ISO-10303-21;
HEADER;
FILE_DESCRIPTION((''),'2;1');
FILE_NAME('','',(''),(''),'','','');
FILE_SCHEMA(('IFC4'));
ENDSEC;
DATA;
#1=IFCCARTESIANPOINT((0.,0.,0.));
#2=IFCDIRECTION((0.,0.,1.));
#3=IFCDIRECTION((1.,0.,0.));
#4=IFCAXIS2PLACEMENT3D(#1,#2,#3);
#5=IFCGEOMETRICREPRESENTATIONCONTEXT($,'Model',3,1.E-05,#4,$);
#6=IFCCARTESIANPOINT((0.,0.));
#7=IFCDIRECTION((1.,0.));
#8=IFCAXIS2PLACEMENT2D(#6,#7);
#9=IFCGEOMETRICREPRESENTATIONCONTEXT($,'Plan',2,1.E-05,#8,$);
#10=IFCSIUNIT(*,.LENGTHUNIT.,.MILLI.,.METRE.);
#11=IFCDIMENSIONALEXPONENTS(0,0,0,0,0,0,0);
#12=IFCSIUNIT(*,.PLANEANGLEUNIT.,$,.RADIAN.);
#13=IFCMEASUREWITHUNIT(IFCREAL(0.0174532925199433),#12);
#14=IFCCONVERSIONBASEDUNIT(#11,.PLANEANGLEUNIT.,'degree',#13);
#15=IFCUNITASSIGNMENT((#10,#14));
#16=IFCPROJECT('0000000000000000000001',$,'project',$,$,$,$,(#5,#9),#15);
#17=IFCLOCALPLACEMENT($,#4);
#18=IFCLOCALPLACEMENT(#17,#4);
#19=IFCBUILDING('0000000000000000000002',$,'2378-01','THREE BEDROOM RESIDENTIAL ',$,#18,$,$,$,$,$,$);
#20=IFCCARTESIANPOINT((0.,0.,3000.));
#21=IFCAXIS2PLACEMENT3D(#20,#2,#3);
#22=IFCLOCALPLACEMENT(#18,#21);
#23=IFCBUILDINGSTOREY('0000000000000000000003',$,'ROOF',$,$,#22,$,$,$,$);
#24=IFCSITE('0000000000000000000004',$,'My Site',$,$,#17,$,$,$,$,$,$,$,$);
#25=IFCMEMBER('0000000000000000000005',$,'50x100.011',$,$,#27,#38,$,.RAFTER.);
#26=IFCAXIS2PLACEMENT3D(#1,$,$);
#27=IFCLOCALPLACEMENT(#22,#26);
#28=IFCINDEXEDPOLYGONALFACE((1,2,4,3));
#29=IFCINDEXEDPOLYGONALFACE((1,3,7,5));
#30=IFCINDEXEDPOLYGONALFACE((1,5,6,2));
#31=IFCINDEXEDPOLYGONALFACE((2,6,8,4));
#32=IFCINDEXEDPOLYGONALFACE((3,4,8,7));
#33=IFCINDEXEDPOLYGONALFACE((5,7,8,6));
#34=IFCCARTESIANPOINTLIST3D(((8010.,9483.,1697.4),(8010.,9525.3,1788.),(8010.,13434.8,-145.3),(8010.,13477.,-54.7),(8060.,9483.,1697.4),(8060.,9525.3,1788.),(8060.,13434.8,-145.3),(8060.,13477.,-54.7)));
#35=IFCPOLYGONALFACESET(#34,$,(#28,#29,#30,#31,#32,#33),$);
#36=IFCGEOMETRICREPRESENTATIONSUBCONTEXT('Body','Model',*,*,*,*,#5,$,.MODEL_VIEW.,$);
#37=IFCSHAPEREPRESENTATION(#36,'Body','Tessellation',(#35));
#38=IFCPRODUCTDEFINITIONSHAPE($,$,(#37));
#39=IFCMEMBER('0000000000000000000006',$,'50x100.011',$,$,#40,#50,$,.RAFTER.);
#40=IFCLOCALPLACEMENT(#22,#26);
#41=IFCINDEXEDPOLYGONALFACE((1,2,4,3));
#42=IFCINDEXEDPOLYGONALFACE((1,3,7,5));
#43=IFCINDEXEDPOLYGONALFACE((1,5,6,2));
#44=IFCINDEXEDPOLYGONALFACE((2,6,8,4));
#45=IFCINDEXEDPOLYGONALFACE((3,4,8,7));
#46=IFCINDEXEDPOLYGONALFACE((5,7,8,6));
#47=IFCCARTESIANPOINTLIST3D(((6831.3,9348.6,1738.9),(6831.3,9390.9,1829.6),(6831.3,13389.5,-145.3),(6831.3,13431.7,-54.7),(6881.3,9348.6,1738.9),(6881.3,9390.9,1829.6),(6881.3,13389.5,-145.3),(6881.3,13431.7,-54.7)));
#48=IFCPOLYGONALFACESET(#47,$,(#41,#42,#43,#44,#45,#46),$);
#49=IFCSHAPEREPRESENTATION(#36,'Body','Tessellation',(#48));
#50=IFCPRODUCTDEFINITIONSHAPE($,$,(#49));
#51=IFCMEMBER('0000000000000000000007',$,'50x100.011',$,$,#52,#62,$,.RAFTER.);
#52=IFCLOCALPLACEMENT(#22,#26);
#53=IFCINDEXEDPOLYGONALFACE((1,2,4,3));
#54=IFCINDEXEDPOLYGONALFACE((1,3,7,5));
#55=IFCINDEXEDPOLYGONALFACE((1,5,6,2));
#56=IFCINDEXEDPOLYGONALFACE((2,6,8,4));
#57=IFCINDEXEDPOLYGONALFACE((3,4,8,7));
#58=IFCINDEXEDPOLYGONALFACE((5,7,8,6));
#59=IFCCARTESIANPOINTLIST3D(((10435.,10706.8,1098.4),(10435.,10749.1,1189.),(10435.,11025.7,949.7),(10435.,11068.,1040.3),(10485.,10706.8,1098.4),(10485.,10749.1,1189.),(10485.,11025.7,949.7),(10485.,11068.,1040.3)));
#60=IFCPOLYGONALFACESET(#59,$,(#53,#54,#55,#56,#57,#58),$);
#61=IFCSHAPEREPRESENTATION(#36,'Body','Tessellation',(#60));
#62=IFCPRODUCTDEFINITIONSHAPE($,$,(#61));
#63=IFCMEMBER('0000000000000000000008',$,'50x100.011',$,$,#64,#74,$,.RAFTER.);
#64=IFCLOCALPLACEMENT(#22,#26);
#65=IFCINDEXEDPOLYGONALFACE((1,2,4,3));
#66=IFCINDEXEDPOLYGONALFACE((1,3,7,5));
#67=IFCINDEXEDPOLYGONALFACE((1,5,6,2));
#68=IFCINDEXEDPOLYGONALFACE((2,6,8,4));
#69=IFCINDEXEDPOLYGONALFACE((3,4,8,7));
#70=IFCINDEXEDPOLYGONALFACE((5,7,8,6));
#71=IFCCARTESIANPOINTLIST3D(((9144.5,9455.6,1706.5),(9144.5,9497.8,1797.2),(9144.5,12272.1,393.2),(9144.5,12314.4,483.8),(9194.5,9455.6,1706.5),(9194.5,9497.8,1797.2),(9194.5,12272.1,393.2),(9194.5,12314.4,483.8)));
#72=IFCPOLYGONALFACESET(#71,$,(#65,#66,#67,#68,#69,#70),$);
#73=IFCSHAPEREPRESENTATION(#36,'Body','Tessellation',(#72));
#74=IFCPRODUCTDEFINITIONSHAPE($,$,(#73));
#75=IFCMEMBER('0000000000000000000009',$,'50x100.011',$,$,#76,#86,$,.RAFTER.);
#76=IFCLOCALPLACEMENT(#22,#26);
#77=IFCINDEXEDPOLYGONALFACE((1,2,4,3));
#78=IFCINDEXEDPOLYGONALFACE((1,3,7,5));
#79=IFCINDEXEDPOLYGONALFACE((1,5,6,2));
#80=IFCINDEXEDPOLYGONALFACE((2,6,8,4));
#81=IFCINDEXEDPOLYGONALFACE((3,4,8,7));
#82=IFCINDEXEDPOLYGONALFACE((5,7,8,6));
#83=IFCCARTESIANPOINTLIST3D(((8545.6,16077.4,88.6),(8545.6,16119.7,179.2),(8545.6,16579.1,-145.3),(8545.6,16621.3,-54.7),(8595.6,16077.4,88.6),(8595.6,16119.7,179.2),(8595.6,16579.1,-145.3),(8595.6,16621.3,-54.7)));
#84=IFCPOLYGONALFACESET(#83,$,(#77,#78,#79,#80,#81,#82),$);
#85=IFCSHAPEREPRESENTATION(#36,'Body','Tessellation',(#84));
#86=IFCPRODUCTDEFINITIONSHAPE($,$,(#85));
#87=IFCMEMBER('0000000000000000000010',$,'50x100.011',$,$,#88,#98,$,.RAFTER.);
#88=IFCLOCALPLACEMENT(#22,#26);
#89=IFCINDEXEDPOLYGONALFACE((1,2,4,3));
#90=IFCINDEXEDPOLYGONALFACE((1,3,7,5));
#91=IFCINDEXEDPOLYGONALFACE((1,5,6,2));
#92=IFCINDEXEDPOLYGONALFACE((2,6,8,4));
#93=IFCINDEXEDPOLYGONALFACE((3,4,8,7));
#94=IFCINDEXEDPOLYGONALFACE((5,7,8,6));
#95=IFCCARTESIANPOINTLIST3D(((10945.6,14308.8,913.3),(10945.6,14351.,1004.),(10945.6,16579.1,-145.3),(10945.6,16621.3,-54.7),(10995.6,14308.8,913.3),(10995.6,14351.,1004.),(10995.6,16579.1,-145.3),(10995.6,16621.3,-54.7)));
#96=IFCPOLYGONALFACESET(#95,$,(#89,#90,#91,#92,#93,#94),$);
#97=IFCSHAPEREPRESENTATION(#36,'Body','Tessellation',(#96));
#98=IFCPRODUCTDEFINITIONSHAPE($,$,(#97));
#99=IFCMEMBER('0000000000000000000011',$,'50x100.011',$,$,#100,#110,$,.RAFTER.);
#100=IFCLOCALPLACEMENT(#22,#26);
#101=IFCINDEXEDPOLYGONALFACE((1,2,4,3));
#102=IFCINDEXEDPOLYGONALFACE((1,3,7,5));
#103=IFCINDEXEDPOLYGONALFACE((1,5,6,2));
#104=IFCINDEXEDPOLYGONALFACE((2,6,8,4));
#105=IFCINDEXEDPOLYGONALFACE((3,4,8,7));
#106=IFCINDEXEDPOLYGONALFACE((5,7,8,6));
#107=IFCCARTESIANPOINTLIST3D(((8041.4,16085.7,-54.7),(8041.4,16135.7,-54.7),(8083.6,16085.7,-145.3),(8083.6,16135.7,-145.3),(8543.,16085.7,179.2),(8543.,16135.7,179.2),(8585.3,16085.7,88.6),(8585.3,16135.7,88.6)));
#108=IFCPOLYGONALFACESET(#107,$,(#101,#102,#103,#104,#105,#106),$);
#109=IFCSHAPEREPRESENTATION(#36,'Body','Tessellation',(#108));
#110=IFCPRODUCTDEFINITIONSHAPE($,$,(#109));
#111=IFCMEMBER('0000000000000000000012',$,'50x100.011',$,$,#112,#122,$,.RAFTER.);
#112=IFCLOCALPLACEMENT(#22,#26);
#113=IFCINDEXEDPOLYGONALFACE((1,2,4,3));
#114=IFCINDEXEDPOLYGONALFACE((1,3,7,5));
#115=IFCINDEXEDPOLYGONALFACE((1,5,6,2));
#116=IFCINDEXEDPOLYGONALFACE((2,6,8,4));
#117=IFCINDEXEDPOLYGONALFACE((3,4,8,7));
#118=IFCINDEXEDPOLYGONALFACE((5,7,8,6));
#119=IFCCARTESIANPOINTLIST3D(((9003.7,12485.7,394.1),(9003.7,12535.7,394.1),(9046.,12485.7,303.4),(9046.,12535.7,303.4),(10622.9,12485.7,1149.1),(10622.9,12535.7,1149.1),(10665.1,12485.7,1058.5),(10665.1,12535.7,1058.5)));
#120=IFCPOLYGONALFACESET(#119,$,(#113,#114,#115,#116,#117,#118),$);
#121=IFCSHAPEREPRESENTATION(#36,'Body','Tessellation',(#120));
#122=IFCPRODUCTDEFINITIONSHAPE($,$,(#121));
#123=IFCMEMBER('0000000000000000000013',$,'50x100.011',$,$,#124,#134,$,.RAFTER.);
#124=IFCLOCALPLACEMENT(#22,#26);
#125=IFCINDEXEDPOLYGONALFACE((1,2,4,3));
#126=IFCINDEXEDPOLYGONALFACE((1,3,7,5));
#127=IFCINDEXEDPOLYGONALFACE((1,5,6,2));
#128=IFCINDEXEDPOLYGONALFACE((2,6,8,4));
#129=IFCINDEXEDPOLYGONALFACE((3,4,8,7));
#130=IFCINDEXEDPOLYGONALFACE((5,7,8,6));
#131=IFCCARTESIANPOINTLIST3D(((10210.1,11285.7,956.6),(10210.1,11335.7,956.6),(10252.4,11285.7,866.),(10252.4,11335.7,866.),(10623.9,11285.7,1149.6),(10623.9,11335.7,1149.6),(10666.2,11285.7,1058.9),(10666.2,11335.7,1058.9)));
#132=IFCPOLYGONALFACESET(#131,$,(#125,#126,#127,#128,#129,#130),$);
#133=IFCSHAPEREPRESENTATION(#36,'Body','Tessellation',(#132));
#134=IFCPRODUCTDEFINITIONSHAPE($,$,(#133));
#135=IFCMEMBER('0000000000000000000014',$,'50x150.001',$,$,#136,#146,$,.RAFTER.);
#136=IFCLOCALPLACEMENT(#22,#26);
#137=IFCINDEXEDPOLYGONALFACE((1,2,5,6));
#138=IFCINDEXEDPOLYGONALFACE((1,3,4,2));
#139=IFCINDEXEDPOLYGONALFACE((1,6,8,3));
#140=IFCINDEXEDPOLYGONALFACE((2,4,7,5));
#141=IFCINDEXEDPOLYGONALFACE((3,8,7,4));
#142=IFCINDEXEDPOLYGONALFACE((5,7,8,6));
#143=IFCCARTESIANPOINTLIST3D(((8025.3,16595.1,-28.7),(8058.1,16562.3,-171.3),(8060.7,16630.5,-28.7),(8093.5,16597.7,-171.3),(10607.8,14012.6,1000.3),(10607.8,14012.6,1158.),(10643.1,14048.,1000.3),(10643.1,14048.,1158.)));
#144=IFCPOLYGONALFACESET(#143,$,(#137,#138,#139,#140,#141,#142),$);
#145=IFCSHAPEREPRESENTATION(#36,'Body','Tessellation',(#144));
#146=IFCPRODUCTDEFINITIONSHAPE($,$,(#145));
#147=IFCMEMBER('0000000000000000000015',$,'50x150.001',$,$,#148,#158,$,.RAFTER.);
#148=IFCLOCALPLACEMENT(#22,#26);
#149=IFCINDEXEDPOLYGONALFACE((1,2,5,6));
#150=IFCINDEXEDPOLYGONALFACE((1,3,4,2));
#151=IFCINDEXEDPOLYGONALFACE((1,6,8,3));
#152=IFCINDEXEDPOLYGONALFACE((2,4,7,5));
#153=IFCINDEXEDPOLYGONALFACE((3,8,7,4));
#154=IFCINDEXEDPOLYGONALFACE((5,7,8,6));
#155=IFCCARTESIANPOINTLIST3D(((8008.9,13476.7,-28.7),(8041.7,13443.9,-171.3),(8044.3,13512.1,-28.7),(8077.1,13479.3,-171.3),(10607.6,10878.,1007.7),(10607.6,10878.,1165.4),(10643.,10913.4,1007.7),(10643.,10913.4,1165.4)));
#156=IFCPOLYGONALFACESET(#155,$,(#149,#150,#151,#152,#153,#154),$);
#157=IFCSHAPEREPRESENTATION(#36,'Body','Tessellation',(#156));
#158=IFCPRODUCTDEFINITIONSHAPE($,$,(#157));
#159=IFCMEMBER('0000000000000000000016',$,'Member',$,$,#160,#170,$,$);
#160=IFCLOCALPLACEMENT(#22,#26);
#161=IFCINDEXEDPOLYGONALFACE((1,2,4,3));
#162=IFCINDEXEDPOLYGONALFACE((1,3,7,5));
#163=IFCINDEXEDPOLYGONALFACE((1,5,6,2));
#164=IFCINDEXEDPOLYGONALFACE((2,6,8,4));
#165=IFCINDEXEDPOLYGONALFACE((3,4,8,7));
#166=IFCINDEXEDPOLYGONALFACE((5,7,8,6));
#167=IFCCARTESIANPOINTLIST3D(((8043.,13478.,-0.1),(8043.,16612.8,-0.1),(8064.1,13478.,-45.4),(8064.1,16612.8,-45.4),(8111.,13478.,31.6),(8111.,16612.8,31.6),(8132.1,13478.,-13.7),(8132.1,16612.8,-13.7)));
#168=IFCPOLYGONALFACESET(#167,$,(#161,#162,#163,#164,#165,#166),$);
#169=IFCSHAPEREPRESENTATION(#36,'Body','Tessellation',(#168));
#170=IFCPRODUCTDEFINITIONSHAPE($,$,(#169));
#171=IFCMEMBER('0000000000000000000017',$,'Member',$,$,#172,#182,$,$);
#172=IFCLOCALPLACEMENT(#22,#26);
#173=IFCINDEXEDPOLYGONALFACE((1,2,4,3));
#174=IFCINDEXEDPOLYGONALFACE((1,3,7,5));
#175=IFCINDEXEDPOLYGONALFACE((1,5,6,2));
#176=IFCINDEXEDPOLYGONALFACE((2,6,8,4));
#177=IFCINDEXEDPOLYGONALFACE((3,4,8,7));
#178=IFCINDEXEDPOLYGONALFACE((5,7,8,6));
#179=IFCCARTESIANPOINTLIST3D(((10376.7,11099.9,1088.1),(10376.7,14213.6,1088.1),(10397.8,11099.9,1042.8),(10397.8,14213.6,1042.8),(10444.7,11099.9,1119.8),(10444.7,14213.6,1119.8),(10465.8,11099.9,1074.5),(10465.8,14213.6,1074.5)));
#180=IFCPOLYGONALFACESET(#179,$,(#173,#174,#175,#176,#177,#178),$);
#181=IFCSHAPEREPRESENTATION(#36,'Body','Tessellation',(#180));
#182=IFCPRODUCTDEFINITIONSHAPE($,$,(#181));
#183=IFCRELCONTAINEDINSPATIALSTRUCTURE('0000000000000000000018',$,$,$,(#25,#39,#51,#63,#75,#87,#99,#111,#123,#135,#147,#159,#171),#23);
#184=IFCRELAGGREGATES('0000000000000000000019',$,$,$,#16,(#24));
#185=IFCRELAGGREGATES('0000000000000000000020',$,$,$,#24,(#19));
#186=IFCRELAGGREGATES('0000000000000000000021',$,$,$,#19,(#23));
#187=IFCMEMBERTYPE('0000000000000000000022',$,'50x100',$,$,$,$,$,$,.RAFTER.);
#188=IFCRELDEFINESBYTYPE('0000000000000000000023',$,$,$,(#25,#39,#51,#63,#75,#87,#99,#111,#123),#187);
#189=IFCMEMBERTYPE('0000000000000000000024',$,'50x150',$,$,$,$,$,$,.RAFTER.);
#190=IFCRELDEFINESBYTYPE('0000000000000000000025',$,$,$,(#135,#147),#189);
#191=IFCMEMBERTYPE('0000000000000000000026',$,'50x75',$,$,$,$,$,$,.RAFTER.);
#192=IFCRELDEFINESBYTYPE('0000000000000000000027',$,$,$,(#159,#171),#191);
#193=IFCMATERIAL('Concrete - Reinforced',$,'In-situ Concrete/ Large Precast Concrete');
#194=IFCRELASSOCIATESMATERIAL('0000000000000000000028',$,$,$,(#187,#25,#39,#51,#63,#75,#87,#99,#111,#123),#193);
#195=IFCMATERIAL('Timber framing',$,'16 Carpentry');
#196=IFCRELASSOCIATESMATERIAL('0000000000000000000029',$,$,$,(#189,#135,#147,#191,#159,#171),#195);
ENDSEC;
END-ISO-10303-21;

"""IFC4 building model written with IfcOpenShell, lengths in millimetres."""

from ifc_helpers import new_model, entity, si_unit, converted_unit, frame, origin_with_axes, origin_2d_with_axis, place, context, subcontext, project, spatial, rectangle, extrude, clip, halfspace, material, material_profile, profile_set, profile_usage, type_object, element, save


model = new_model("IFC4")

# Units and contexts
model_context = context("Model", 3, precision=1e-05, world=origin_with_axes())
plan_context = context("Plan", 2, precision=1e-05, world=origin_2d_with_axis())
body_context = subcontext(model_context, "Body", "Model", "MODEL_VIEW")
ifc_project = project(units=[si_unit("LENGTHUNIT", "METRE", prefix="MILLI"), converted_unit("PLANEANGLEUNIT", "degree", entity("IfcReal", 0.0174532925199433), si_unit("PLANEANGLEUNIT", "RADIAN"), dimensions=[0, 0, 0, 0, 0, 0, 0])], contexts=[model_context, plan_context])

# Site, building, storey
site_placement = place(None, origin_with_axes())
site = spatial("IfcSite", under=ifc_project, at=site_placement, Name="My Site")
building_placement = place(site_placement, origin_with_axes())
building = spatial("IfcBuilding", under=site, at=building_placement, Name="2378-01", Description="THREE BEDROOM RESIDENTIAL ")
storey_placement = place(building_placement, frame((0.0, 0.0, 3000.0), z_axis=(0.0, 0.0, 1.0), x_axis=(1.0, 0.0, 0.0)))
storey = spatial("IfcBuildingStorey", under=building, at=storey_placement, Name="ROOF")

# Members
ifc_material_1 = material(Name="Concrete - Reinforced", Category="In-situ Concrete/ Large Precast Concrete")
ifc_material_profile_1 = material_profile(ifc_material_1, rectangle(XDim=50.0, YDim=100.0), Name="Core Layer", Category="LoadBearing", Priority=1)
ifc_profile_set_1 = profile_set([ifc_material_profile_1], Name="wood")
ifc_profile_usage_1 = profile_usage(ifc_profile_set_1)
member_type_1 = type_object("IfcMemberType", Name="50x100", PredefinedType="RAFTER", material=ifc_profile_set_1)
member_1_placement = place(storey_placement, frame((8035.0, 13455.9, -100.0), z_axis=(0.0, -0.906308, 0.422618), x_axis=(1.0, 0.0, 0.0)))
element("IfcMember", 1, at=member_1_placement, inside=storey, type_object=member_type_1, material=ifc_profile_usage_1, Name="50x100.011", PredefinedType="RAFTER", context=body_context, shape_type="SweptSolid", body=[
    extrude(rectangle(XDim=50.0, YDim=100.0), origin_with_axes(), (0.0, 0.0, 1.0), 4360.3),
])
ifc_profile_usage_2 = profile_usage(ifc_profile_set_1)
member_2_placement = place(storey_placement, frame((6856.3, 13410.6, -100.0), z_axis=(0.0, -0.906308, 0.422618), x_axis=(1.0, 0.0, 0.0)))
element("IfcMember", 2, at=member_2_placement, inside=storey, type_object=member_type_1, material=ifc_profile_usage_2, Name="50x100.011", PredefinedType="RAFTER", context=body_context, shape_type="SweptSolid", body=[
    extrude(rectangle(XDim=50.0, YDim=100.0), origin_with_axes(), (0.0, 0.0, 1.0), 4458.6),
])
ifc_profile_usage_3 = profile_usage(ifc_profile_set_1)
member_3_placement = place(storey_placement, frame((10460.0, 11046.9, 995.0), z_axis=(0.0, -0.906308, 0.422618), x_axis=(1.0, 0.0, 0.0)))
element("IfcMember", 3, at=member_3_placement, inside=storey, type_object=member_type_1, material=ifc_profile_usage_3, Name="50x100.011", PredefinedType="RAFTER", context=body_context, shape_type="SweptSolid", body=[
    extrude(rectangle(XDim=50.0, YDim=100.0), origin_with_axes(), (0.0, 0.0, 1.0), 351.9),
])
ifc_profile_usage_4 = profile_usage(ifc_profile_set_1)
member_4_placement = place(storey_placement, frame((9169.5, 12293.3, 438.5), z_axis=(0.0, -0.906308, 0.422618), x_axis=(1.0, 0.0, 0.0)))
element("IfcMember", 4, at=member_4_placement, inside=storey, type_object=member_type_1, material=ifc_profile_usage_4, Name="50x100.011", PredefinedType="RAFTER", context=body_context, shape_type="SweptSolid", body=[
    extrude(rectangle(XDim=50.0, YDim=100.0), origin_with_axes(), (0.0, 0.0, 1.0), 3107.7),
])
ifc_profile_usage_5 = profile_usage(ifc_profile_set_1, cardinal=5)
member_5_placement = place(storey_placement, frame((8570.6, 16600.2, -100.0), z_axis=(0.0, -0.906308, 0.422618), x_axis=(1.0, 0.0, 0.0)))
element("IfcMember", 5, at=member_5_placement, inside=storey, type_object=member_type_1, material=ifc_profile_usage_5, Name="50x100.011", PredefinedType="RAFTER", context=body_context, shape_type="SweptSolid", body=[
    extrude(rectangle(XDim=50.0, YDim=100.0), origin_with_axes(), (0.0, 0.0, 1.0), 553.5),
])
ifc_profile_usage_6 = profile_usage(ifc_profile_set_1)
member_6_placement = place(storey_placement, frame((10970.6, 16600.2, -100.0), z_axis=(0.0, -0.906308, 0.422618), x_axis=(1.0, 0.0, 0.0)))
element("IfcMember", 6, at=member_6_placement, inside=storey, type_object=member_type_1, material=ifc_profile_usage_6, Name="50x100.011", PredefinedType="RAFTER", context=body_context, shape_type="SweptSolid", body=[
    extrude(rectangle(XDim=50.0, YDim=100.0), origin_with_axes(), (0.0, 0.0, 1.0), 2505.0),
])
ifc_profile_usage_7 = profile_usage(ifc_profile_set_1, cardinal=5)
member_7_placement = place(storey_placement, frame((8062.5, 16110.7, -100.0), z_axis=(0.906308, 0.0, 0.422618), x_axis=(0.0, 1.0, 0.0)))
element("IfcMember", 7, at=member_7_placement, inside=storey, type_object=member_type_1, material=ifc_profile_usage_7, Name="50x100.011", PredefinedType="RAFTER", context=body_context, shape_type="SweptSolid", body=[
    extrude(rectangle(XDim=50.0, YDim=100.0), origin_with_axes(), (0.0, 0.0, 1.0), 553.5),
])
ifc_profile_usage_8 = profile_usage(ifc_profile_set_1, cardinal=5)
member_8_placement = place(storey_placement, frame((9024.9, 12510.7, 348.8), z_axis=(0.906308, 0.0, 0.422618), x_axis=(0.0, 1.0, 0.0)))
element("IfcMember", 8, at=member_8_placement, inside=storey, type_object=member_type_1, material=ifc_profile_usage_8, Name="50x100.011", PredefinedType="RAFTER", context=body_context, shape_type="SweptSolid", body=[
    extrude(rectangle(XDim=50.0, YDim=100.0), origin_with_axes(), (0.0, 0.0, 1.0), 1786.5),
])
ifc_profile_usage_9 = profile_usage(ifc_profile_set_1, cardinal=5)
member_9_placement = place(storey_placement, frame((10231.3, 11310.7, 911.3), z_axis=(0.906308, 0.0, 0.422618), x_axis=(0.0, 1.0, 0.0)))
element("IfcMember", 9, at=member_9_placement, inside=storey, type_object=member_type_1, material=ifc_profile_usage_9, Name="50x100.011", PredefinedType="RAFTER", context=body_context, shape_type="SweptSolid", body=[
    extrude(rectangle(XDim=50.0, YDim=100.0), origin_with_axes(), (0.0, 0.0, 1.0), 456.5),
])
ifc_material_2 = material(Name="Timber framing", Category="16 Carpentry")
ifc_material_profile_2 = material_profile(ifc_material_2, rectangle(XDim=50.0, YDim=150.0), Name="Lumber", Category="LoadBearing", Priority=1)
ifc_profile_set_2 = profile_set([ifc_material_profile_2], Name="wood")
ifc_profile_usage_10 = profile_usage(ifc_profile_set_2)
member_type_2 = type_object("IfcMemberType", Name="50x150", PredefinedType="RAFTER", material=ifc_profile_set_2)
member_10_placement = place(storey_placement, frame((8059.4, 16596.4, -100.0), z_axis=(0.672499, -0.672499, 0.309017), x_axis=(0.707107, 0.707107, 0.0)))
element("IfcMember", 10, at=member_10_placement, inside=storey, type_object=member_type_2, material=ifc_profile_usage_10, Name="50x150.001", PredefinedType="RAFTER", context=body_context, shape_type="Clipping", body=[
    clip(extrude(rectangle(XDim=50.0, YDim=150.0), origin_with_axes(), (0.0, 0.0, 1.0), 3965.7), halfspace(frame((3654.0, -1121.4, 3451.4), z_axis=(0.0, -0.309017, 0.951057), x_axis=(-1.0, 0.0, 0.0)), False)),
])
ifc_profile_usage_11 = profile_usage(ifc_profile_set_2)
member_11_placement = place(storey_placement, frame((8043.0, 13478.0, -100.0), z_axis=(0.672499, -0.672499, 0.309017), x_axis=(0.707107, 0.707107, 0.0)))
element("IfcMember", 11, at=member_11_placement, inside=storey, type_object=member_type_2, material=ifc_profile_usage_11, Name="50x150.001", PredefinedType="RAFTER", context=body_context, shape_type="Clipping", body=[
    clip(extrude(rectangle(XDim=50.0, YDim=150.0), origin_with_axes(), (0.0, 0.0, 1.0), 3989.9), halfspace(frame((167.7, -45.3, 3825.1), z_axis=(0.0, -0.309017, 0.951057), x_axis=(-1.0, 0.0, 0.0)), False)),
])
ifc_material_profile_3 = material_profile(ifc_material_2, rectangle(XDim=50.0, YDim=75.0), Name="Lumber2", Category="Substrate", Priority=2)
ifc_profile_set_3 = profile_set([ifc_material_profile_3])
ifc_profile_usage_12 = profile_usage(ifc_profile_set_3, cardinal=5)
member_type_3 = type_object("IfcMemberType", Name="50x75", PredefinedType="RAFTER", material=ifc_profile_set_3)
member_12_placement = place(storey_placement, frame((8087.6, 13478.0, -6.9), z_axis=(0.0, 1.0, 0.0), x_axis=(-0.422618, 0.0, 0.906308)))
element("IfcMember", 12, at=member_12_placement, inside=storey, type_object=member_type_3, material=ifc_profile_usage_12, Name="Member", context=body_context, shape_type="SweptSolid", body=[
    extrude(rectangle(XDim=50.0, YDim=75.0), origin_with_axes(), (0.0, 0.0, 1.0), 3134.8),
])
ifc_profile_usage_13 = profile_usage(ifc_profile_set_3, cardinal=5)
member_13_placement = place(storey_placement, frame((10421.3, 11099.9, 1081.3), z_axis=(0.0, 1.0, 0.0), x_axis=(-0.422618, 0.0, 0.906308)))
element("IfcMember", 13, at=member_13_placement, inside=storey, type_object=member_type_3, material=ifc_profile_usage_13, Name="Member", context=body_context, shape_type="SweptSolid", body=[
    extrude(rectangle(XDim=50.0, YDim=75.0), origin_with_axes(), (0.0, 0.0, 1.0), 3113.7),
])

save(model, "model.ifc")
